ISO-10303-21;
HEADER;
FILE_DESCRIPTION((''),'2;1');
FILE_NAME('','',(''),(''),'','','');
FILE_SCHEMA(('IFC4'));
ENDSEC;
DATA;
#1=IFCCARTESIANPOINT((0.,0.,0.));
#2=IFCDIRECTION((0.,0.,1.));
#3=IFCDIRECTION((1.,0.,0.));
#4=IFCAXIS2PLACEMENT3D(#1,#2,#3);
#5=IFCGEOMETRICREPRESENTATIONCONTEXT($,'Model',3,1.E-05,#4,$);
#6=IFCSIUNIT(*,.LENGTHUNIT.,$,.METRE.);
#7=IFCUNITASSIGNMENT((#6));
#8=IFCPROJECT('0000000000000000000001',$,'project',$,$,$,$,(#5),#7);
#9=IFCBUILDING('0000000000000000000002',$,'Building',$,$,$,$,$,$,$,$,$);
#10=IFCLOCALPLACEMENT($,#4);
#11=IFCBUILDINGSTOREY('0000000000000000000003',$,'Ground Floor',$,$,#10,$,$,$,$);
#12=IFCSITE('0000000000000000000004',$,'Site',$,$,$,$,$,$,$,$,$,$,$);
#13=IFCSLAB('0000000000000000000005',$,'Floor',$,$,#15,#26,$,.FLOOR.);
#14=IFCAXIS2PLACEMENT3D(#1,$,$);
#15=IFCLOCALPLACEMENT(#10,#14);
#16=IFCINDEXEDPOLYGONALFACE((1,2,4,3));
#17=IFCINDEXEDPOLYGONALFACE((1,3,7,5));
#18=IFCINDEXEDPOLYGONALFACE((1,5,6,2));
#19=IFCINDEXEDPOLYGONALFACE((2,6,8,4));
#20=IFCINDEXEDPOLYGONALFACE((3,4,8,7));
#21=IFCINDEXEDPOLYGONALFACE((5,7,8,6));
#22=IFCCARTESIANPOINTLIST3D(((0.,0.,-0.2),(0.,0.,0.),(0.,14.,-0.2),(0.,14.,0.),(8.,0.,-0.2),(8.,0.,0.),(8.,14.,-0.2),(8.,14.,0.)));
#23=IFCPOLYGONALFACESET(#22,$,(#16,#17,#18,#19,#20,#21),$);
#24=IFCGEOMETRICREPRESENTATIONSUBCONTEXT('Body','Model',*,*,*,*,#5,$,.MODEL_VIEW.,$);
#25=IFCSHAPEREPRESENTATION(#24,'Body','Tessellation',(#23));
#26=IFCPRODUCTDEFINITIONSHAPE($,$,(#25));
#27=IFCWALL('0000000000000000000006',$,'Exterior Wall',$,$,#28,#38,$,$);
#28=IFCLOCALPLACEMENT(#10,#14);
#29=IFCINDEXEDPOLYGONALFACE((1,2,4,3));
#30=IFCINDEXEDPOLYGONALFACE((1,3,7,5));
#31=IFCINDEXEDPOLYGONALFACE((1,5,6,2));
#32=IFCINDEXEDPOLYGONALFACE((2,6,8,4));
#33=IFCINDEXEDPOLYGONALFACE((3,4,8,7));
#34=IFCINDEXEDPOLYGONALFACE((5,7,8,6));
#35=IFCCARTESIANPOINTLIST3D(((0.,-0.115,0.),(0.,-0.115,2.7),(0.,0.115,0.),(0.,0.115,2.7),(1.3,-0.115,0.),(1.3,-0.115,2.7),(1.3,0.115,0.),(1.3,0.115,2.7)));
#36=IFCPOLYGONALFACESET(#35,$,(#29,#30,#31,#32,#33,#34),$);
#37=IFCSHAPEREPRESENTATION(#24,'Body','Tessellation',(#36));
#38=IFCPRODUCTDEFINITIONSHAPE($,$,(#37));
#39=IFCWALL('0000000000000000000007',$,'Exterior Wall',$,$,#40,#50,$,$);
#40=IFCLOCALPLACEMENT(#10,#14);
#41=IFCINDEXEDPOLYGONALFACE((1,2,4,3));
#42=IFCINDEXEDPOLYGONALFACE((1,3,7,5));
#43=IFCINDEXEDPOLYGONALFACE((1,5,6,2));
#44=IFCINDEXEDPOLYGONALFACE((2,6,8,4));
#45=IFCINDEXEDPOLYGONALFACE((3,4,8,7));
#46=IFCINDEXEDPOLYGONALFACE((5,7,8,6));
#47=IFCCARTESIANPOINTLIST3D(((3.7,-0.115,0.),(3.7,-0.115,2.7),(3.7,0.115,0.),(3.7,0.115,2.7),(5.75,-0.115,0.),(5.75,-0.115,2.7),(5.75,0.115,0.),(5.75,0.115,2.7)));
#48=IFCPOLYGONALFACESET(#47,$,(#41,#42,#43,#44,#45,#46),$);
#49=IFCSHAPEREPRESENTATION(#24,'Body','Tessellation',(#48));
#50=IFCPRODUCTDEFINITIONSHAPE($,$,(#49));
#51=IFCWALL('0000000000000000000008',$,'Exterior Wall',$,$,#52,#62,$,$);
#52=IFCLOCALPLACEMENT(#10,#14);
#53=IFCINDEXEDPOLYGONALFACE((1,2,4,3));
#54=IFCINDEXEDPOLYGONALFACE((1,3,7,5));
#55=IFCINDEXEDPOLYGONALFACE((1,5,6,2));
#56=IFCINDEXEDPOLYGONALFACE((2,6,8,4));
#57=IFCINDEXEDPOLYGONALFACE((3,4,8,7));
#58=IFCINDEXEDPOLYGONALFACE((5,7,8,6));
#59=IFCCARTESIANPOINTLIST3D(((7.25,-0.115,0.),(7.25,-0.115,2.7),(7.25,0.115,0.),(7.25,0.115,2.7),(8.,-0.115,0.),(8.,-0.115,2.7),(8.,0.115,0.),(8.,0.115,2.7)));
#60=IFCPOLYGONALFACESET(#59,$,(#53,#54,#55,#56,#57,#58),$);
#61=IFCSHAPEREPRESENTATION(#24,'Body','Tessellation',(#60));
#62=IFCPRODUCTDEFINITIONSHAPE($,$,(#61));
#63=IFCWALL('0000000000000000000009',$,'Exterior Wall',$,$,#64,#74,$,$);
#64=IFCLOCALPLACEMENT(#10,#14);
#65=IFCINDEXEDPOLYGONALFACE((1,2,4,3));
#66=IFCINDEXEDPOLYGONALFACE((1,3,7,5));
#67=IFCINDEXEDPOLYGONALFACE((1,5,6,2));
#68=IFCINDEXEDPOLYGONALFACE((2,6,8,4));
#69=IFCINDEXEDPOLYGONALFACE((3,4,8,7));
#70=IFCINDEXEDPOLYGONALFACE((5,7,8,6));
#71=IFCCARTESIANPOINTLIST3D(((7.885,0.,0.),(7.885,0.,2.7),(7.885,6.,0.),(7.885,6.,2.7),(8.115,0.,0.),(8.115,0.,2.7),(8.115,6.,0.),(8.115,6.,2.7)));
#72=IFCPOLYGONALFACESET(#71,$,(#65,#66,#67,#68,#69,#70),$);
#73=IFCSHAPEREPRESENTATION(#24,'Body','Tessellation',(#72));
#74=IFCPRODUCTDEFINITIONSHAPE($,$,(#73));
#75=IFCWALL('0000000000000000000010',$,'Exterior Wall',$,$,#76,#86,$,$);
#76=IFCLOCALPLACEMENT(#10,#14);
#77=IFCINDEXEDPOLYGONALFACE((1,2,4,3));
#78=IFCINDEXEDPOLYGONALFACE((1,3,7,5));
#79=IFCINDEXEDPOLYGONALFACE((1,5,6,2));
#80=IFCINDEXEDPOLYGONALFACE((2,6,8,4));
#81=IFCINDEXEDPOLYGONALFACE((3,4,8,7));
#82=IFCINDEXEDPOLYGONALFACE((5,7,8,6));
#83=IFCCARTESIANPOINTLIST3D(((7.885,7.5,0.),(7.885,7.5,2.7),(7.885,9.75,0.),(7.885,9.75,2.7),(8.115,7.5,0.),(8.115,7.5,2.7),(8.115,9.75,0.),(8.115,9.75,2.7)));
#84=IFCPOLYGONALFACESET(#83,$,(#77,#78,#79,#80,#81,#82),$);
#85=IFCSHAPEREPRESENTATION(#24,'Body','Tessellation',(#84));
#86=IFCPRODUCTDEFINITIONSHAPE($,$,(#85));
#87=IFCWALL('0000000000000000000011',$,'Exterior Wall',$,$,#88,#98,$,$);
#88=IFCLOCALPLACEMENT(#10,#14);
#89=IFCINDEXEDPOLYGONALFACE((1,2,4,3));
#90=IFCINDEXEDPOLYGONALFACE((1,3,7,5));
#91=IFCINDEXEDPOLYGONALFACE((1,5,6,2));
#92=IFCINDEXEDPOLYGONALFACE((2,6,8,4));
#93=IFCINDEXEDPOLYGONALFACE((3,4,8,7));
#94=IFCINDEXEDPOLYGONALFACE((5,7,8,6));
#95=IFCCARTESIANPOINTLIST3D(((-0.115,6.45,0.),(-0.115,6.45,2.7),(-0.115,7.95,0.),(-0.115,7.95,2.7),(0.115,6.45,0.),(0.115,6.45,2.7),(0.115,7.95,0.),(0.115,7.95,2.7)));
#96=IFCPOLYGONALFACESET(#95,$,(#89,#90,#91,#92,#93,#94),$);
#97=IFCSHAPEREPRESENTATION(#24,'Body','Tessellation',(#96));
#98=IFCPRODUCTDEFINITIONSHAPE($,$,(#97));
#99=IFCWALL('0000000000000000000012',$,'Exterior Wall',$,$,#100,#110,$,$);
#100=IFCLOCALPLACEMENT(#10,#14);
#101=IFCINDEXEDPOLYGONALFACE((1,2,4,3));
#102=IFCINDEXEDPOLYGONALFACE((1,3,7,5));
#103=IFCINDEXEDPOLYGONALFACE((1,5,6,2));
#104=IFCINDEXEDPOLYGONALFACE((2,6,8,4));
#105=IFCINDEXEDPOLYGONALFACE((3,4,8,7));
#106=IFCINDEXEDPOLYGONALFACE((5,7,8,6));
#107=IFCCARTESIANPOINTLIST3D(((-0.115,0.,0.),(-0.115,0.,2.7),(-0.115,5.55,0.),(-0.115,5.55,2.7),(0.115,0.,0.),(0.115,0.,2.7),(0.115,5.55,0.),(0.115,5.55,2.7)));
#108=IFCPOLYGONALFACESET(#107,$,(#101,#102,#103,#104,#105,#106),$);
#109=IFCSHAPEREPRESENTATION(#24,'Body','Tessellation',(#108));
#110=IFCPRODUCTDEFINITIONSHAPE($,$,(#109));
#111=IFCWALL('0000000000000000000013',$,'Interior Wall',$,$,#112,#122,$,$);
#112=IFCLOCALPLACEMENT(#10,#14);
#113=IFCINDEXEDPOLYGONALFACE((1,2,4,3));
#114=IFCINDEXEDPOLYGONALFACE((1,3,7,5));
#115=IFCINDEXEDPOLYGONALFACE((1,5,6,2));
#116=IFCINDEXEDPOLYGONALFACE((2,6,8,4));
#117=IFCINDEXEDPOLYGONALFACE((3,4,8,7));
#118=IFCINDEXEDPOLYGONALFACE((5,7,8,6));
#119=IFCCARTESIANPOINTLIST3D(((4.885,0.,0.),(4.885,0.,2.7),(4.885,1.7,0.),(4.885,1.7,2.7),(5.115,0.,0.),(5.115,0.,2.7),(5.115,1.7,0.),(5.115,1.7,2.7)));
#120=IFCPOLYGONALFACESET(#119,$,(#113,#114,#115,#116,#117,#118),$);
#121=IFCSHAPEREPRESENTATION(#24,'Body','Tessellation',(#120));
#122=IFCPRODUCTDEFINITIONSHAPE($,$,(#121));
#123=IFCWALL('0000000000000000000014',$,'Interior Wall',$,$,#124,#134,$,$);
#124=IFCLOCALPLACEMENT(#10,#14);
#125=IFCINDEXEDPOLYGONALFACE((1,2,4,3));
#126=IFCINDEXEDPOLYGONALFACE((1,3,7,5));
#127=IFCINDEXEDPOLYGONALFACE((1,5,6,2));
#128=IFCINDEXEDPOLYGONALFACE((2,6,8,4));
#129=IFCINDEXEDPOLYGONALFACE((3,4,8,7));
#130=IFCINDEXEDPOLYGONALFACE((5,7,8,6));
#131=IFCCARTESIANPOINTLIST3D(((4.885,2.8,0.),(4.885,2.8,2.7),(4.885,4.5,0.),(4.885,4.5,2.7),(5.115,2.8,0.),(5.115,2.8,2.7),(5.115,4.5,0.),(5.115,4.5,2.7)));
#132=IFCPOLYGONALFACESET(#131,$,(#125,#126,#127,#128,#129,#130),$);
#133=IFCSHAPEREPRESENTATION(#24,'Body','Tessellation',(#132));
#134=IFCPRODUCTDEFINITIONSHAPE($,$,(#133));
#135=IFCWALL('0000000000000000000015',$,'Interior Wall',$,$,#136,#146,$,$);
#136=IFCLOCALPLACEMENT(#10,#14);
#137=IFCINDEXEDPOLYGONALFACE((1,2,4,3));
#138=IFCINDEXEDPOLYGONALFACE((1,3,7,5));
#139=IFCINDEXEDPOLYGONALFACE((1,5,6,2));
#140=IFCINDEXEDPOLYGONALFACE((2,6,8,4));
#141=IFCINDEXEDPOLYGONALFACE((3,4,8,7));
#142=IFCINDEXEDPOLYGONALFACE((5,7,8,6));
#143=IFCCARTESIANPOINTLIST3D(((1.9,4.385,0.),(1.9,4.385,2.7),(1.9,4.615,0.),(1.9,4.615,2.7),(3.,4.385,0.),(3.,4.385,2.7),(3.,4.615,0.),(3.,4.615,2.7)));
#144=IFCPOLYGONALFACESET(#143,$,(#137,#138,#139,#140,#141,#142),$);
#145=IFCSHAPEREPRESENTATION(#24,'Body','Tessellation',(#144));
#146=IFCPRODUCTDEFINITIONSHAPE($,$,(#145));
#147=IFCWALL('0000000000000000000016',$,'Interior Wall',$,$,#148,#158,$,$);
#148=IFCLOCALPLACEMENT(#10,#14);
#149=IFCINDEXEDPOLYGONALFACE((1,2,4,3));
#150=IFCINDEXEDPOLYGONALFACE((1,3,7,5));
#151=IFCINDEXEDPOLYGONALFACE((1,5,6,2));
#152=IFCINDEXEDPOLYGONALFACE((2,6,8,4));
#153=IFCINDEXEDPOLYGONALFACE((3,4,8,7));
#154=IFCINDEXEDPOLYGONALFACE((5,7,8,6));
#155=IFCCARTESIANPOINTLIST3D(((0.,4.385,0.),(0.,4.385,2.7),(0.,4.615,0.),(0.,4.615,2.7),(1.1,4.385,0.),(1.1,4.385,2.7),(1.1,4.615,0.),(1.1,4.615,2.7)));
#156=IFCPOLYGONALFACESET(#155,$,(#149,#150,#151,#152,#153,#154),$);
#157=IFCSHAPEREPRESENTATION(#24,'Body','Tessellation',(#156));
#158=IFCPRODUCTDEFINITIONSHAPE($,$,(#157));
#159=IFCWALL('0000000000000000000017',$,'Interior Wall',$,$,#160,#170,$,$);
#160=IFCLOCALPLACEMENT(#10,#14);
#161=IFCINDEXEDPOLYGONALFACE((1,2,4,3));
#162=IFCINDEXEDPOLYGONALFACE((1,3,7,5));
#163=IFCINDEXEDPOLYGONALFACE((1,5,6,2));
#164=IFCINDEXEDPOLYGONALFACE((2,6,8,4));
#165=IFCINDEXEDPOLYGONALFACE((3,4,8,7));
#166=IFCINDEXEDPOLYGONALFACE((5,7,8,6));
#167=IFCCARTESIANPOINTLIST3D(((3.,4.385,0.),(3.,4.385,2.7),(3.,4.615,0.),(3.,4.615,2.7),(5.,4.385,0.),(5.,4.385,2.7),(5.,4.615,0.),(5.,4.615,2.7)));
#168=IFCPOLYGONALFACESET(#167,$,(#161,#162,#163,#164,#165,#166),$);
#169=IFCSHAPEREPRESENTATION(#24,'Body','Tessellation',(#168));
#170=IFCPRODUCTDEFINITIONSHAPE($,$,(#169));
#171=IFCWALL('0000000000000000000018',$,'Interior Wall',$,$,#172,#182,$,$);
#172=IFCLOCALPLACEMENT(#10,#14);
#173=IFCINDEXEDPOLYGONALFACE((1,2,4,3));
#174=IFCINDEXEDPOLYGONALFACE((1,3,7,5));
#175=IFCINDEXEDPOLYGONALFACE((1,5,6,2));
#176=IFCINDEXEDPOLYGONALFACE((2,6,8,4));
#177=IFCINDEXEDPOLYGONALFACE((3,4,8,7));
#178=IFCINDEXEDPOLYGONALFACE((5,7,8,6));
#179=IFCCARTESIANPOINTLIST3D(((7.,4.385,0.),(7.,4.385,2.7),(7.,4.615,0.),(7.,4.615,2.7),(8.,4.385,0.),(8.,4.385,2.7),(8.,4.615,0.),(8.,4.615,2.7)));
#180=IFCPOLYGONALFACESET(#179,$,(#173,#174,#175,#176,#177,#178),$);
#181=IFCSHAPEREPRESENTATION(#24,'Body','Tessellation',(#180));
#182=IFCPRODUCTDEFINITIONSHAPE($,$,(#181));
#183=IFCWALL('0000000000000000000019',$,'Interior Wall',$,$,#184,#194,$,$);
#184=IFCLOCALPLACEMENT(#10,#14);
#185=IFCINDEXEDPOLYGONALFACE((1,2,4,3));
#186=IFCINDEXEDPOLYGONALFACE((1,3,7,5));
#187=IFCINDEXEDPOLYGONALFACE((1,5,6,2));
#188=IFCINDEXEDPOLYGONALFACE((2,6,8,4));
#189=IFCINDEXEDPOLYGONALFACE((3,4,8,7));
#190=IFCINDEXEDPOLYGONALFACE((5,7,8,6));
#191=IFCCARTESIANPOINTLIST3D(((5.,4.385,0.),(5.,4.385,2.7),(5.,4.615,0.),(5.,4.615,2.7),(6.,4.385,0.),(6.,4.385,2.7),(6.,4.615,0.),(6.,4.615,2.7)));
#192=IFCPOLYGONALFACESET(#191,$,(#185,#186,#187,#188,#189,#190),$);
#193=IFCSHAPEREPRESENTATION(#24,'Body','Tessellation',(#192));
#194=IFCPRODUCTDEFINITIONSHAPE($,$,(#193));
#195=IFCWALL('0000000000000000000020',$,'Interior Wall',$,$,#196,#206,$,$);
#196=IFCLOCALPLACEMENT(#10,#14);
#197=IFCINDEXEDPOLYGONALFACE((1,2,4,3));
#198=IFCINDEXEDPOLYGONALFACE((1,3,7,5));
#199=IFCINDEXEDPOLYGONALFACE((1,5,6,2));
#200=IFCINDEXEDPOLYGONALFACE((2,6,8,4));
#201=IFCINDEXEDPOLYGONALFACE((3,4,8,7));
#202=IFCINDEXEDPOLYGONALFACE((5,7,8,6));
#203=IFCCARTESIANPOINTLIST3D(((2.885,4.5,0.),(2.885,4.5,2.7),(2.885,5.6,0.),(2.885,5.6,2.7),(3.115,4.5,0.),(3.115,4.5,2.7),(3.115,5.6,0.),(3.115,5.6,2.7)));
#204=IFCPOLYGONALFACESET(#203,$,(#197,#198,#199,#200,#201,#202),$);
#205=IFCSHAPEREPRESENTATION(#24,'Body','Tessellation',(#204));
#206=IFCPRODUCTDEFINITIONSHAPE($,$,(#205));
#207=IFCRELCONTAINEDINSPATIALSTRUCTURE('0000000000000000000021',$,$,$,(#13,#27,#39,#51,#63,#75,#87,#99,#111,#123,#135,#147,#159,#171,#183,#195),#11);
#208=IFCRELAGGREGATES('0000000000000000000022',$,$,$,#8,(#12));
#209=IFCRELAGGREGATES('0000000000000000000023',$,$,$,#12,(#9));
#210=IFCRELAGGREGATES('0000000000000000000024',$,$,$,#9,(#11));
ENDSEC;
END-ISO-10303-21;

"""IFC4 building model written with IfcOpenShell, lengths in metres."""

from ifc_helpers import new_model, si_unit, frame, origin_with_axes, place, context, subcontext, project, spatial, indexed_curve, outline, extrude, element, save


model = new_model("IFC4")

# Units and contexts
model_context = context("Model", 3, precision=1e-05, world=origin_with_axes())
body_context = subcontext(model_context, "Body", "Model", "MODEL_VIEW")
ifc_project = project(units=[si_unit("LENGTHUNIT", "METRE")], contexts=[model_context])

# Site, building, storey
site = spatial("IfcSite", under=ifc_project, Name="Site")
building = spatial("IfcBuilding", under=site, Name="Building")
storey_placement = place(None, origin_with_axes())
storey = spatial("IfcBuildingStorey", under=building, at=storey_placement, Name="Ground Floor")

# Slab
slab_placement = place(storey_placement, frame((0.0, 0.0, -0.2), z_axis=(0.0, 0.0, 1.0), x_axis=(1.0, 0.0, 0.0)))
element("IfcSlab", 1, at=slab_placement, inside=storey, Name="Floor", PredefinedType="FLOOR", context=body_context, shape_type="SweptSolid", body=[
    extrude(outline(indexed_curve([(0.0, 0.0), (8.0, 0.0), (8.0, 14.0), (0.0, 14.0)])), None, (0.0, 0.0, 1.0), 0.2),
])

# Walls
wall_1_placement = place(storey_placement, origin_with_axes())
element("IfcWall", 2, at=wall_1_placement, inside=storey, Name="Exterior Wall", context=body_context, shape_type="SweptSolid", body=[
    extrude(outline(indexed_curve([(0.0, 0.0), (0.0, 0.23), (1.3, 0.23), (1.3, 0.0), (0.0, 0.0)], self_intersect=False)), frame((0.0, -0.115, 0.0), z_axis=(0.0, 0.0, 1.0), x_axis=(1.0, 0.0, 0.0)), (0.0, 0.0, 1.0), 2.7),
])
wall_2_placement = place(storey_placement, frame((3.7, 0.0, 0.0), z_axis=(0.0, 0.0, 1.0), x_axis=(1.0, 0.0, 0.0)))
element("IfcWall", 3, at=wall_2_placement, inside=storey, Name="Exterior Wall", context=body_context, shape_type="SweptSolid", body=[
    extrude(outline(indexed_curve([(0.0, 0.0), (0.0, 0.23), (2.05, 0.23), (2.05, 0.0), (0.0, 0.0)], self_intersect=False)), frame((0.0, -0.115, 0.0), z_axis=(0.0, 0.0, 1.0), x_axis=(1.0, 0.0, 0.0)), (0.0, 0.0, 1.0), 2.7),
])
wall_3_placement = place(storey_placement, frame((7.25, 0.0, 0.0), z_axis=(0.0, 0.0, 1.0), x_axis=(1.0, 0.0, 0.0)))
element("IfcWall", 4, at=wall_3_placement, inside=storey, Name="Exterior Wall", context=body_context, shape_type="SweptSolid", body=[
    extrude(outline(indexed_curve([(0.0, 0.0), (0.0, 0.23), (0.75, 0.23), (0.75, 0.0), (0.0, 0.0)], self_intersect=False)), frame((0.0, -0.115, 0.0), z_axis=(0.0, 0.0, 1.0), x_axis=(1.0, 0.0, 0.0)), (0.0, 0.0, 1.0), 2.7),
])
wall_4_placement = place(storey_placement, frame((8.0, 0.0, 0.0), z_axis=(0.0, 0.0, 1.0), x_axis=(0.0, 1.0, 0.0)))
element("IfcWall", 5, at=wall_4_placement, inside=storey, Name="Exterior Wall", context=body_context, shape_type="SweptSolid", body=[
    extrude(outline(indexed_curve([(0.0, 0.0), (0.0, 0.23), (6.0, 0.23), (6.0, 0.0), (0.0, 0.0)], self_intersect=False)), frame((0.0, -0.115, 0.0), z_axis=(0.0, 0.0, 1.0), x_axis=(1.0, 0.0, 0.0)), (0.0, 0.0, 1.0), 2.7),
])
wall_5_placement = place(storey_placement, frame((8.0, 7.5, 0.0), z_axis=(0.0, 0.0, 1.0), x_axis=(0.0, 1.0, 0.0)))
element("IfcWall", 6, at=wall_5_placement, inside=storey, Name="Exterior Wall", context=body_context, shape_type="SweptSolid", body=[
    extrude(outline(indexed_curve([(0.0, 0.0), (0.0, 0.23), (2.25, 0.23), (2.25, 0.0), (0.0, 0.0)], self_intersect=False)), frame((0.0, -0.115, 0.0), z_axis=(0.0, 0.0, 1.0), x_axis=(1.0, 0.0, 0.0)), (0.0, 0.0, 1.0), 2.7),
])
wall_6_placement = place(storey_placement, frame((0.0, 7.95, 0.0), z_axis=(0.0, 0.0, 1.0), x_axis=(0.0, -1.0, 0.0)))
element("IfcWall", 7, at=wall_6_placement, inside=storey, Name="Exterior Wall", context=body_context, shape_type="SweptSolid", body=[
    extrude(outline(indexed_curve([(0.0, 0.0), (0.0, 0.23), (1.5, 0.23), (1.5, 0.0), (0.0, 0.0)], self_intersect=False)), frame((0.0, -0.115, 0.0), z_axis=(0.0, 0.0, 1.0), x_axis=(1.0, 0.0, 0.0)), (0.0, 0.0, 1.0), 2.7),
])
wall_7_placement = place(storey_placement, frame((0.0, 5.55, 0.0), z_axis=(0.0, 0.0, 1.0), x_axis=(0.0, -1.0, 0.0)))
element("IfcWall", 8, at=wall_7_placement, inside=storey, Name="Exterior Wall", context=body_context, shape_type="SweptSolid", body=[
    extrude(outline(indexed_curve([(0.0, 0.0), (0.0, 0.23), (5.55, 0.23), (5.55, 0.0), (0.0, 0.0)], self_intersect=False)), frame((0.0, -0.115, 0.0), z_axis=(0.0, 0.0, 1.0), x_axis=(1.0, 0.0, 0.0)), (0.0, 0.0, 1.0), 2.7),
])
wall_8_placement = place(storey_placement, frame((5.0, 0.0, 0.0), z_axis=(0.0, 0.0, 1.0), x_axis=(0.0, 1.0, 0.0)))
element("IfcWall", 9, at=wall_8_placement, inside=storey, Name="Interior Wall", context=body_context, shape_type="SweptSolid", body=[
    extrude(outline(indexed_curve([(0.0, 0.0), (0.0, 0.23), (1.7, 0.23), (1.7, 0.0), (0.0, 0.0)], self_intersect=False)), frame((0.0, -0.115, 0.0), z_axis=(0.0, 0.0, 1.0), x_axis=(1.0, 0.0, 0.0)), (0.0, 0.0, 1.0), 2.7),
])
wall_9_placement = place(storey_placement, frame((5.0, 2.8, 0.0), z_axis=(0.0, 0.0, 1.0), x_axis=(0.0, 1.0, 0.0)))
element("IfcWall", 10, at=wall_9_placement, inside=storey, Name="Interior Wall", context=body_context, shape_type="SweptSolid", body=[
    extrude(outline(indexed_curve([(0.0, 0.0), (0.0, 0.23), (1.7, 0.23), (1.7, 0.0), (0.0, 0.0)], self_intersect=False)), frame((0.0, -0.115, 0.0), z_axis=(0.0, 0.0, 1.0), x_axis=(1.0, 0.0, 0.0)), (0.0, 0.0, 1.0), 2.7),
])
for number, where, z_axis, x_axis, name in (
    (11, (3.0, 4.5, 0.0), (0.0, 0.0, 1.0), (-1.0, 0.0, 0.0), "Interior Wall"),
    (12, (1.1, 4.5, 0.0), (0.0, 0.0, 1.0), (-1.0, 0.0, 0.0), "Interior Wall"),
):
    element("IfcWall", number, at=place(storey_placement, frame(where, z_axis=z_axis, x_axis=x_axis)), inside=storey, Name=name, context=body_context, shape_type="SweptSolid", body=[
        extrude(outline(indexed_curve([(0.0, 0.0), (0.0, 0.23), (1.1, 0.23), (1.1, 0.0), (0.0, 0.0)], self_intersect=False)), frame((0.0, -0.115, 0.0), z_axis=(0.0, 0.0, 1.0), x_axis=(1.0, 0.0, 0.0)), (0.0, 0.0, 1.0), 2.7),
    ])
wall_10_placement = place(storey_placement, frame((5.0, 4.5, 0.0), z_axis=(0.0, 0.0, 1.0), x_axis=(-1.0, 0.0, 0.0)))
element("IfcWall", 13, at=wall_10_placement, inside=storey, Name="Interior Wall", context=body_context, shape_type="SweptSolid", body=[
    extrude(outline(indexed_curve([(0.0, 0.0), (0.0, 0.23), (2.0, 0.23), (2.0, 0.0), (0.0, 0.0)], self_intersect=False)), frame((0.0, -0.115, 0.0), z_axis=(0.0, 0.0, 1.0), x_axis=(1.0, 0.0, 0.0)), (0.0, 0.0, 1.0), 2.7),
])
for number, where, z_axis, x_axis, name in (
    (14, (8.0, 4.5, 0.0), (0.0, 0.0, 1.0), (-1.0, 0.0, 0.0), "Interior Wall"),
    (15, (6.0, 4.5, 0.0), (0.0, 0.0, 1.0), (-1.0, 0.0, 0.0), "Interior Wall"),
):
    element("IfcWall", number, at=place(storey_placement, frame(where, z_axis=z_axis, x_axis=x_axis)), inside=storey, Name=name, context=body_context, shape_type="SweptSolid", body=[
        extrude(outline(indexed_curve([(0.0, 0.0), (0.0, 0.23), (1.0, 0.23), (1.0, 0.0), (0.0, 0.0)], self_intersect=False)), frame((0.0, -0.115, 0.0), z_axis=(0.0, 0.0, 1.0), x_axis=(1.0, 0.0, 0.0)), (0.0, 0.0, 1.0), 2.7),
    ])
for number, where, z_axis, x_axis, name in (
    (16, (3.0, 4.5, 0.0), (0.0, 0.0, 1.0), (0.0, 1.0, 0.0), "Interior Wall"),
):
    element("IfcWall", number, at=place(storey_placement, frame(where, z_axis=z_axis, x_axis=x_axis)), inside=storey, Name=name, context=body_context, shape_type="SweptSolid", body=[
        extrude(outline(indexed_curve([(0.0, 0.0), (0.0, 0.23), (1.1, 0.23), (1.1, 0.0), (0.0, 0.0)], self_intersect=False)), frame((0.0, -0.115, 0.0), z_axis=(0.0, 0.0, 1.0), x_axis=(1.0, 0.0, 0.0)), (0.0, 0.0, 1.0), 2.7),
    ])

save(model, "model.ifc")
